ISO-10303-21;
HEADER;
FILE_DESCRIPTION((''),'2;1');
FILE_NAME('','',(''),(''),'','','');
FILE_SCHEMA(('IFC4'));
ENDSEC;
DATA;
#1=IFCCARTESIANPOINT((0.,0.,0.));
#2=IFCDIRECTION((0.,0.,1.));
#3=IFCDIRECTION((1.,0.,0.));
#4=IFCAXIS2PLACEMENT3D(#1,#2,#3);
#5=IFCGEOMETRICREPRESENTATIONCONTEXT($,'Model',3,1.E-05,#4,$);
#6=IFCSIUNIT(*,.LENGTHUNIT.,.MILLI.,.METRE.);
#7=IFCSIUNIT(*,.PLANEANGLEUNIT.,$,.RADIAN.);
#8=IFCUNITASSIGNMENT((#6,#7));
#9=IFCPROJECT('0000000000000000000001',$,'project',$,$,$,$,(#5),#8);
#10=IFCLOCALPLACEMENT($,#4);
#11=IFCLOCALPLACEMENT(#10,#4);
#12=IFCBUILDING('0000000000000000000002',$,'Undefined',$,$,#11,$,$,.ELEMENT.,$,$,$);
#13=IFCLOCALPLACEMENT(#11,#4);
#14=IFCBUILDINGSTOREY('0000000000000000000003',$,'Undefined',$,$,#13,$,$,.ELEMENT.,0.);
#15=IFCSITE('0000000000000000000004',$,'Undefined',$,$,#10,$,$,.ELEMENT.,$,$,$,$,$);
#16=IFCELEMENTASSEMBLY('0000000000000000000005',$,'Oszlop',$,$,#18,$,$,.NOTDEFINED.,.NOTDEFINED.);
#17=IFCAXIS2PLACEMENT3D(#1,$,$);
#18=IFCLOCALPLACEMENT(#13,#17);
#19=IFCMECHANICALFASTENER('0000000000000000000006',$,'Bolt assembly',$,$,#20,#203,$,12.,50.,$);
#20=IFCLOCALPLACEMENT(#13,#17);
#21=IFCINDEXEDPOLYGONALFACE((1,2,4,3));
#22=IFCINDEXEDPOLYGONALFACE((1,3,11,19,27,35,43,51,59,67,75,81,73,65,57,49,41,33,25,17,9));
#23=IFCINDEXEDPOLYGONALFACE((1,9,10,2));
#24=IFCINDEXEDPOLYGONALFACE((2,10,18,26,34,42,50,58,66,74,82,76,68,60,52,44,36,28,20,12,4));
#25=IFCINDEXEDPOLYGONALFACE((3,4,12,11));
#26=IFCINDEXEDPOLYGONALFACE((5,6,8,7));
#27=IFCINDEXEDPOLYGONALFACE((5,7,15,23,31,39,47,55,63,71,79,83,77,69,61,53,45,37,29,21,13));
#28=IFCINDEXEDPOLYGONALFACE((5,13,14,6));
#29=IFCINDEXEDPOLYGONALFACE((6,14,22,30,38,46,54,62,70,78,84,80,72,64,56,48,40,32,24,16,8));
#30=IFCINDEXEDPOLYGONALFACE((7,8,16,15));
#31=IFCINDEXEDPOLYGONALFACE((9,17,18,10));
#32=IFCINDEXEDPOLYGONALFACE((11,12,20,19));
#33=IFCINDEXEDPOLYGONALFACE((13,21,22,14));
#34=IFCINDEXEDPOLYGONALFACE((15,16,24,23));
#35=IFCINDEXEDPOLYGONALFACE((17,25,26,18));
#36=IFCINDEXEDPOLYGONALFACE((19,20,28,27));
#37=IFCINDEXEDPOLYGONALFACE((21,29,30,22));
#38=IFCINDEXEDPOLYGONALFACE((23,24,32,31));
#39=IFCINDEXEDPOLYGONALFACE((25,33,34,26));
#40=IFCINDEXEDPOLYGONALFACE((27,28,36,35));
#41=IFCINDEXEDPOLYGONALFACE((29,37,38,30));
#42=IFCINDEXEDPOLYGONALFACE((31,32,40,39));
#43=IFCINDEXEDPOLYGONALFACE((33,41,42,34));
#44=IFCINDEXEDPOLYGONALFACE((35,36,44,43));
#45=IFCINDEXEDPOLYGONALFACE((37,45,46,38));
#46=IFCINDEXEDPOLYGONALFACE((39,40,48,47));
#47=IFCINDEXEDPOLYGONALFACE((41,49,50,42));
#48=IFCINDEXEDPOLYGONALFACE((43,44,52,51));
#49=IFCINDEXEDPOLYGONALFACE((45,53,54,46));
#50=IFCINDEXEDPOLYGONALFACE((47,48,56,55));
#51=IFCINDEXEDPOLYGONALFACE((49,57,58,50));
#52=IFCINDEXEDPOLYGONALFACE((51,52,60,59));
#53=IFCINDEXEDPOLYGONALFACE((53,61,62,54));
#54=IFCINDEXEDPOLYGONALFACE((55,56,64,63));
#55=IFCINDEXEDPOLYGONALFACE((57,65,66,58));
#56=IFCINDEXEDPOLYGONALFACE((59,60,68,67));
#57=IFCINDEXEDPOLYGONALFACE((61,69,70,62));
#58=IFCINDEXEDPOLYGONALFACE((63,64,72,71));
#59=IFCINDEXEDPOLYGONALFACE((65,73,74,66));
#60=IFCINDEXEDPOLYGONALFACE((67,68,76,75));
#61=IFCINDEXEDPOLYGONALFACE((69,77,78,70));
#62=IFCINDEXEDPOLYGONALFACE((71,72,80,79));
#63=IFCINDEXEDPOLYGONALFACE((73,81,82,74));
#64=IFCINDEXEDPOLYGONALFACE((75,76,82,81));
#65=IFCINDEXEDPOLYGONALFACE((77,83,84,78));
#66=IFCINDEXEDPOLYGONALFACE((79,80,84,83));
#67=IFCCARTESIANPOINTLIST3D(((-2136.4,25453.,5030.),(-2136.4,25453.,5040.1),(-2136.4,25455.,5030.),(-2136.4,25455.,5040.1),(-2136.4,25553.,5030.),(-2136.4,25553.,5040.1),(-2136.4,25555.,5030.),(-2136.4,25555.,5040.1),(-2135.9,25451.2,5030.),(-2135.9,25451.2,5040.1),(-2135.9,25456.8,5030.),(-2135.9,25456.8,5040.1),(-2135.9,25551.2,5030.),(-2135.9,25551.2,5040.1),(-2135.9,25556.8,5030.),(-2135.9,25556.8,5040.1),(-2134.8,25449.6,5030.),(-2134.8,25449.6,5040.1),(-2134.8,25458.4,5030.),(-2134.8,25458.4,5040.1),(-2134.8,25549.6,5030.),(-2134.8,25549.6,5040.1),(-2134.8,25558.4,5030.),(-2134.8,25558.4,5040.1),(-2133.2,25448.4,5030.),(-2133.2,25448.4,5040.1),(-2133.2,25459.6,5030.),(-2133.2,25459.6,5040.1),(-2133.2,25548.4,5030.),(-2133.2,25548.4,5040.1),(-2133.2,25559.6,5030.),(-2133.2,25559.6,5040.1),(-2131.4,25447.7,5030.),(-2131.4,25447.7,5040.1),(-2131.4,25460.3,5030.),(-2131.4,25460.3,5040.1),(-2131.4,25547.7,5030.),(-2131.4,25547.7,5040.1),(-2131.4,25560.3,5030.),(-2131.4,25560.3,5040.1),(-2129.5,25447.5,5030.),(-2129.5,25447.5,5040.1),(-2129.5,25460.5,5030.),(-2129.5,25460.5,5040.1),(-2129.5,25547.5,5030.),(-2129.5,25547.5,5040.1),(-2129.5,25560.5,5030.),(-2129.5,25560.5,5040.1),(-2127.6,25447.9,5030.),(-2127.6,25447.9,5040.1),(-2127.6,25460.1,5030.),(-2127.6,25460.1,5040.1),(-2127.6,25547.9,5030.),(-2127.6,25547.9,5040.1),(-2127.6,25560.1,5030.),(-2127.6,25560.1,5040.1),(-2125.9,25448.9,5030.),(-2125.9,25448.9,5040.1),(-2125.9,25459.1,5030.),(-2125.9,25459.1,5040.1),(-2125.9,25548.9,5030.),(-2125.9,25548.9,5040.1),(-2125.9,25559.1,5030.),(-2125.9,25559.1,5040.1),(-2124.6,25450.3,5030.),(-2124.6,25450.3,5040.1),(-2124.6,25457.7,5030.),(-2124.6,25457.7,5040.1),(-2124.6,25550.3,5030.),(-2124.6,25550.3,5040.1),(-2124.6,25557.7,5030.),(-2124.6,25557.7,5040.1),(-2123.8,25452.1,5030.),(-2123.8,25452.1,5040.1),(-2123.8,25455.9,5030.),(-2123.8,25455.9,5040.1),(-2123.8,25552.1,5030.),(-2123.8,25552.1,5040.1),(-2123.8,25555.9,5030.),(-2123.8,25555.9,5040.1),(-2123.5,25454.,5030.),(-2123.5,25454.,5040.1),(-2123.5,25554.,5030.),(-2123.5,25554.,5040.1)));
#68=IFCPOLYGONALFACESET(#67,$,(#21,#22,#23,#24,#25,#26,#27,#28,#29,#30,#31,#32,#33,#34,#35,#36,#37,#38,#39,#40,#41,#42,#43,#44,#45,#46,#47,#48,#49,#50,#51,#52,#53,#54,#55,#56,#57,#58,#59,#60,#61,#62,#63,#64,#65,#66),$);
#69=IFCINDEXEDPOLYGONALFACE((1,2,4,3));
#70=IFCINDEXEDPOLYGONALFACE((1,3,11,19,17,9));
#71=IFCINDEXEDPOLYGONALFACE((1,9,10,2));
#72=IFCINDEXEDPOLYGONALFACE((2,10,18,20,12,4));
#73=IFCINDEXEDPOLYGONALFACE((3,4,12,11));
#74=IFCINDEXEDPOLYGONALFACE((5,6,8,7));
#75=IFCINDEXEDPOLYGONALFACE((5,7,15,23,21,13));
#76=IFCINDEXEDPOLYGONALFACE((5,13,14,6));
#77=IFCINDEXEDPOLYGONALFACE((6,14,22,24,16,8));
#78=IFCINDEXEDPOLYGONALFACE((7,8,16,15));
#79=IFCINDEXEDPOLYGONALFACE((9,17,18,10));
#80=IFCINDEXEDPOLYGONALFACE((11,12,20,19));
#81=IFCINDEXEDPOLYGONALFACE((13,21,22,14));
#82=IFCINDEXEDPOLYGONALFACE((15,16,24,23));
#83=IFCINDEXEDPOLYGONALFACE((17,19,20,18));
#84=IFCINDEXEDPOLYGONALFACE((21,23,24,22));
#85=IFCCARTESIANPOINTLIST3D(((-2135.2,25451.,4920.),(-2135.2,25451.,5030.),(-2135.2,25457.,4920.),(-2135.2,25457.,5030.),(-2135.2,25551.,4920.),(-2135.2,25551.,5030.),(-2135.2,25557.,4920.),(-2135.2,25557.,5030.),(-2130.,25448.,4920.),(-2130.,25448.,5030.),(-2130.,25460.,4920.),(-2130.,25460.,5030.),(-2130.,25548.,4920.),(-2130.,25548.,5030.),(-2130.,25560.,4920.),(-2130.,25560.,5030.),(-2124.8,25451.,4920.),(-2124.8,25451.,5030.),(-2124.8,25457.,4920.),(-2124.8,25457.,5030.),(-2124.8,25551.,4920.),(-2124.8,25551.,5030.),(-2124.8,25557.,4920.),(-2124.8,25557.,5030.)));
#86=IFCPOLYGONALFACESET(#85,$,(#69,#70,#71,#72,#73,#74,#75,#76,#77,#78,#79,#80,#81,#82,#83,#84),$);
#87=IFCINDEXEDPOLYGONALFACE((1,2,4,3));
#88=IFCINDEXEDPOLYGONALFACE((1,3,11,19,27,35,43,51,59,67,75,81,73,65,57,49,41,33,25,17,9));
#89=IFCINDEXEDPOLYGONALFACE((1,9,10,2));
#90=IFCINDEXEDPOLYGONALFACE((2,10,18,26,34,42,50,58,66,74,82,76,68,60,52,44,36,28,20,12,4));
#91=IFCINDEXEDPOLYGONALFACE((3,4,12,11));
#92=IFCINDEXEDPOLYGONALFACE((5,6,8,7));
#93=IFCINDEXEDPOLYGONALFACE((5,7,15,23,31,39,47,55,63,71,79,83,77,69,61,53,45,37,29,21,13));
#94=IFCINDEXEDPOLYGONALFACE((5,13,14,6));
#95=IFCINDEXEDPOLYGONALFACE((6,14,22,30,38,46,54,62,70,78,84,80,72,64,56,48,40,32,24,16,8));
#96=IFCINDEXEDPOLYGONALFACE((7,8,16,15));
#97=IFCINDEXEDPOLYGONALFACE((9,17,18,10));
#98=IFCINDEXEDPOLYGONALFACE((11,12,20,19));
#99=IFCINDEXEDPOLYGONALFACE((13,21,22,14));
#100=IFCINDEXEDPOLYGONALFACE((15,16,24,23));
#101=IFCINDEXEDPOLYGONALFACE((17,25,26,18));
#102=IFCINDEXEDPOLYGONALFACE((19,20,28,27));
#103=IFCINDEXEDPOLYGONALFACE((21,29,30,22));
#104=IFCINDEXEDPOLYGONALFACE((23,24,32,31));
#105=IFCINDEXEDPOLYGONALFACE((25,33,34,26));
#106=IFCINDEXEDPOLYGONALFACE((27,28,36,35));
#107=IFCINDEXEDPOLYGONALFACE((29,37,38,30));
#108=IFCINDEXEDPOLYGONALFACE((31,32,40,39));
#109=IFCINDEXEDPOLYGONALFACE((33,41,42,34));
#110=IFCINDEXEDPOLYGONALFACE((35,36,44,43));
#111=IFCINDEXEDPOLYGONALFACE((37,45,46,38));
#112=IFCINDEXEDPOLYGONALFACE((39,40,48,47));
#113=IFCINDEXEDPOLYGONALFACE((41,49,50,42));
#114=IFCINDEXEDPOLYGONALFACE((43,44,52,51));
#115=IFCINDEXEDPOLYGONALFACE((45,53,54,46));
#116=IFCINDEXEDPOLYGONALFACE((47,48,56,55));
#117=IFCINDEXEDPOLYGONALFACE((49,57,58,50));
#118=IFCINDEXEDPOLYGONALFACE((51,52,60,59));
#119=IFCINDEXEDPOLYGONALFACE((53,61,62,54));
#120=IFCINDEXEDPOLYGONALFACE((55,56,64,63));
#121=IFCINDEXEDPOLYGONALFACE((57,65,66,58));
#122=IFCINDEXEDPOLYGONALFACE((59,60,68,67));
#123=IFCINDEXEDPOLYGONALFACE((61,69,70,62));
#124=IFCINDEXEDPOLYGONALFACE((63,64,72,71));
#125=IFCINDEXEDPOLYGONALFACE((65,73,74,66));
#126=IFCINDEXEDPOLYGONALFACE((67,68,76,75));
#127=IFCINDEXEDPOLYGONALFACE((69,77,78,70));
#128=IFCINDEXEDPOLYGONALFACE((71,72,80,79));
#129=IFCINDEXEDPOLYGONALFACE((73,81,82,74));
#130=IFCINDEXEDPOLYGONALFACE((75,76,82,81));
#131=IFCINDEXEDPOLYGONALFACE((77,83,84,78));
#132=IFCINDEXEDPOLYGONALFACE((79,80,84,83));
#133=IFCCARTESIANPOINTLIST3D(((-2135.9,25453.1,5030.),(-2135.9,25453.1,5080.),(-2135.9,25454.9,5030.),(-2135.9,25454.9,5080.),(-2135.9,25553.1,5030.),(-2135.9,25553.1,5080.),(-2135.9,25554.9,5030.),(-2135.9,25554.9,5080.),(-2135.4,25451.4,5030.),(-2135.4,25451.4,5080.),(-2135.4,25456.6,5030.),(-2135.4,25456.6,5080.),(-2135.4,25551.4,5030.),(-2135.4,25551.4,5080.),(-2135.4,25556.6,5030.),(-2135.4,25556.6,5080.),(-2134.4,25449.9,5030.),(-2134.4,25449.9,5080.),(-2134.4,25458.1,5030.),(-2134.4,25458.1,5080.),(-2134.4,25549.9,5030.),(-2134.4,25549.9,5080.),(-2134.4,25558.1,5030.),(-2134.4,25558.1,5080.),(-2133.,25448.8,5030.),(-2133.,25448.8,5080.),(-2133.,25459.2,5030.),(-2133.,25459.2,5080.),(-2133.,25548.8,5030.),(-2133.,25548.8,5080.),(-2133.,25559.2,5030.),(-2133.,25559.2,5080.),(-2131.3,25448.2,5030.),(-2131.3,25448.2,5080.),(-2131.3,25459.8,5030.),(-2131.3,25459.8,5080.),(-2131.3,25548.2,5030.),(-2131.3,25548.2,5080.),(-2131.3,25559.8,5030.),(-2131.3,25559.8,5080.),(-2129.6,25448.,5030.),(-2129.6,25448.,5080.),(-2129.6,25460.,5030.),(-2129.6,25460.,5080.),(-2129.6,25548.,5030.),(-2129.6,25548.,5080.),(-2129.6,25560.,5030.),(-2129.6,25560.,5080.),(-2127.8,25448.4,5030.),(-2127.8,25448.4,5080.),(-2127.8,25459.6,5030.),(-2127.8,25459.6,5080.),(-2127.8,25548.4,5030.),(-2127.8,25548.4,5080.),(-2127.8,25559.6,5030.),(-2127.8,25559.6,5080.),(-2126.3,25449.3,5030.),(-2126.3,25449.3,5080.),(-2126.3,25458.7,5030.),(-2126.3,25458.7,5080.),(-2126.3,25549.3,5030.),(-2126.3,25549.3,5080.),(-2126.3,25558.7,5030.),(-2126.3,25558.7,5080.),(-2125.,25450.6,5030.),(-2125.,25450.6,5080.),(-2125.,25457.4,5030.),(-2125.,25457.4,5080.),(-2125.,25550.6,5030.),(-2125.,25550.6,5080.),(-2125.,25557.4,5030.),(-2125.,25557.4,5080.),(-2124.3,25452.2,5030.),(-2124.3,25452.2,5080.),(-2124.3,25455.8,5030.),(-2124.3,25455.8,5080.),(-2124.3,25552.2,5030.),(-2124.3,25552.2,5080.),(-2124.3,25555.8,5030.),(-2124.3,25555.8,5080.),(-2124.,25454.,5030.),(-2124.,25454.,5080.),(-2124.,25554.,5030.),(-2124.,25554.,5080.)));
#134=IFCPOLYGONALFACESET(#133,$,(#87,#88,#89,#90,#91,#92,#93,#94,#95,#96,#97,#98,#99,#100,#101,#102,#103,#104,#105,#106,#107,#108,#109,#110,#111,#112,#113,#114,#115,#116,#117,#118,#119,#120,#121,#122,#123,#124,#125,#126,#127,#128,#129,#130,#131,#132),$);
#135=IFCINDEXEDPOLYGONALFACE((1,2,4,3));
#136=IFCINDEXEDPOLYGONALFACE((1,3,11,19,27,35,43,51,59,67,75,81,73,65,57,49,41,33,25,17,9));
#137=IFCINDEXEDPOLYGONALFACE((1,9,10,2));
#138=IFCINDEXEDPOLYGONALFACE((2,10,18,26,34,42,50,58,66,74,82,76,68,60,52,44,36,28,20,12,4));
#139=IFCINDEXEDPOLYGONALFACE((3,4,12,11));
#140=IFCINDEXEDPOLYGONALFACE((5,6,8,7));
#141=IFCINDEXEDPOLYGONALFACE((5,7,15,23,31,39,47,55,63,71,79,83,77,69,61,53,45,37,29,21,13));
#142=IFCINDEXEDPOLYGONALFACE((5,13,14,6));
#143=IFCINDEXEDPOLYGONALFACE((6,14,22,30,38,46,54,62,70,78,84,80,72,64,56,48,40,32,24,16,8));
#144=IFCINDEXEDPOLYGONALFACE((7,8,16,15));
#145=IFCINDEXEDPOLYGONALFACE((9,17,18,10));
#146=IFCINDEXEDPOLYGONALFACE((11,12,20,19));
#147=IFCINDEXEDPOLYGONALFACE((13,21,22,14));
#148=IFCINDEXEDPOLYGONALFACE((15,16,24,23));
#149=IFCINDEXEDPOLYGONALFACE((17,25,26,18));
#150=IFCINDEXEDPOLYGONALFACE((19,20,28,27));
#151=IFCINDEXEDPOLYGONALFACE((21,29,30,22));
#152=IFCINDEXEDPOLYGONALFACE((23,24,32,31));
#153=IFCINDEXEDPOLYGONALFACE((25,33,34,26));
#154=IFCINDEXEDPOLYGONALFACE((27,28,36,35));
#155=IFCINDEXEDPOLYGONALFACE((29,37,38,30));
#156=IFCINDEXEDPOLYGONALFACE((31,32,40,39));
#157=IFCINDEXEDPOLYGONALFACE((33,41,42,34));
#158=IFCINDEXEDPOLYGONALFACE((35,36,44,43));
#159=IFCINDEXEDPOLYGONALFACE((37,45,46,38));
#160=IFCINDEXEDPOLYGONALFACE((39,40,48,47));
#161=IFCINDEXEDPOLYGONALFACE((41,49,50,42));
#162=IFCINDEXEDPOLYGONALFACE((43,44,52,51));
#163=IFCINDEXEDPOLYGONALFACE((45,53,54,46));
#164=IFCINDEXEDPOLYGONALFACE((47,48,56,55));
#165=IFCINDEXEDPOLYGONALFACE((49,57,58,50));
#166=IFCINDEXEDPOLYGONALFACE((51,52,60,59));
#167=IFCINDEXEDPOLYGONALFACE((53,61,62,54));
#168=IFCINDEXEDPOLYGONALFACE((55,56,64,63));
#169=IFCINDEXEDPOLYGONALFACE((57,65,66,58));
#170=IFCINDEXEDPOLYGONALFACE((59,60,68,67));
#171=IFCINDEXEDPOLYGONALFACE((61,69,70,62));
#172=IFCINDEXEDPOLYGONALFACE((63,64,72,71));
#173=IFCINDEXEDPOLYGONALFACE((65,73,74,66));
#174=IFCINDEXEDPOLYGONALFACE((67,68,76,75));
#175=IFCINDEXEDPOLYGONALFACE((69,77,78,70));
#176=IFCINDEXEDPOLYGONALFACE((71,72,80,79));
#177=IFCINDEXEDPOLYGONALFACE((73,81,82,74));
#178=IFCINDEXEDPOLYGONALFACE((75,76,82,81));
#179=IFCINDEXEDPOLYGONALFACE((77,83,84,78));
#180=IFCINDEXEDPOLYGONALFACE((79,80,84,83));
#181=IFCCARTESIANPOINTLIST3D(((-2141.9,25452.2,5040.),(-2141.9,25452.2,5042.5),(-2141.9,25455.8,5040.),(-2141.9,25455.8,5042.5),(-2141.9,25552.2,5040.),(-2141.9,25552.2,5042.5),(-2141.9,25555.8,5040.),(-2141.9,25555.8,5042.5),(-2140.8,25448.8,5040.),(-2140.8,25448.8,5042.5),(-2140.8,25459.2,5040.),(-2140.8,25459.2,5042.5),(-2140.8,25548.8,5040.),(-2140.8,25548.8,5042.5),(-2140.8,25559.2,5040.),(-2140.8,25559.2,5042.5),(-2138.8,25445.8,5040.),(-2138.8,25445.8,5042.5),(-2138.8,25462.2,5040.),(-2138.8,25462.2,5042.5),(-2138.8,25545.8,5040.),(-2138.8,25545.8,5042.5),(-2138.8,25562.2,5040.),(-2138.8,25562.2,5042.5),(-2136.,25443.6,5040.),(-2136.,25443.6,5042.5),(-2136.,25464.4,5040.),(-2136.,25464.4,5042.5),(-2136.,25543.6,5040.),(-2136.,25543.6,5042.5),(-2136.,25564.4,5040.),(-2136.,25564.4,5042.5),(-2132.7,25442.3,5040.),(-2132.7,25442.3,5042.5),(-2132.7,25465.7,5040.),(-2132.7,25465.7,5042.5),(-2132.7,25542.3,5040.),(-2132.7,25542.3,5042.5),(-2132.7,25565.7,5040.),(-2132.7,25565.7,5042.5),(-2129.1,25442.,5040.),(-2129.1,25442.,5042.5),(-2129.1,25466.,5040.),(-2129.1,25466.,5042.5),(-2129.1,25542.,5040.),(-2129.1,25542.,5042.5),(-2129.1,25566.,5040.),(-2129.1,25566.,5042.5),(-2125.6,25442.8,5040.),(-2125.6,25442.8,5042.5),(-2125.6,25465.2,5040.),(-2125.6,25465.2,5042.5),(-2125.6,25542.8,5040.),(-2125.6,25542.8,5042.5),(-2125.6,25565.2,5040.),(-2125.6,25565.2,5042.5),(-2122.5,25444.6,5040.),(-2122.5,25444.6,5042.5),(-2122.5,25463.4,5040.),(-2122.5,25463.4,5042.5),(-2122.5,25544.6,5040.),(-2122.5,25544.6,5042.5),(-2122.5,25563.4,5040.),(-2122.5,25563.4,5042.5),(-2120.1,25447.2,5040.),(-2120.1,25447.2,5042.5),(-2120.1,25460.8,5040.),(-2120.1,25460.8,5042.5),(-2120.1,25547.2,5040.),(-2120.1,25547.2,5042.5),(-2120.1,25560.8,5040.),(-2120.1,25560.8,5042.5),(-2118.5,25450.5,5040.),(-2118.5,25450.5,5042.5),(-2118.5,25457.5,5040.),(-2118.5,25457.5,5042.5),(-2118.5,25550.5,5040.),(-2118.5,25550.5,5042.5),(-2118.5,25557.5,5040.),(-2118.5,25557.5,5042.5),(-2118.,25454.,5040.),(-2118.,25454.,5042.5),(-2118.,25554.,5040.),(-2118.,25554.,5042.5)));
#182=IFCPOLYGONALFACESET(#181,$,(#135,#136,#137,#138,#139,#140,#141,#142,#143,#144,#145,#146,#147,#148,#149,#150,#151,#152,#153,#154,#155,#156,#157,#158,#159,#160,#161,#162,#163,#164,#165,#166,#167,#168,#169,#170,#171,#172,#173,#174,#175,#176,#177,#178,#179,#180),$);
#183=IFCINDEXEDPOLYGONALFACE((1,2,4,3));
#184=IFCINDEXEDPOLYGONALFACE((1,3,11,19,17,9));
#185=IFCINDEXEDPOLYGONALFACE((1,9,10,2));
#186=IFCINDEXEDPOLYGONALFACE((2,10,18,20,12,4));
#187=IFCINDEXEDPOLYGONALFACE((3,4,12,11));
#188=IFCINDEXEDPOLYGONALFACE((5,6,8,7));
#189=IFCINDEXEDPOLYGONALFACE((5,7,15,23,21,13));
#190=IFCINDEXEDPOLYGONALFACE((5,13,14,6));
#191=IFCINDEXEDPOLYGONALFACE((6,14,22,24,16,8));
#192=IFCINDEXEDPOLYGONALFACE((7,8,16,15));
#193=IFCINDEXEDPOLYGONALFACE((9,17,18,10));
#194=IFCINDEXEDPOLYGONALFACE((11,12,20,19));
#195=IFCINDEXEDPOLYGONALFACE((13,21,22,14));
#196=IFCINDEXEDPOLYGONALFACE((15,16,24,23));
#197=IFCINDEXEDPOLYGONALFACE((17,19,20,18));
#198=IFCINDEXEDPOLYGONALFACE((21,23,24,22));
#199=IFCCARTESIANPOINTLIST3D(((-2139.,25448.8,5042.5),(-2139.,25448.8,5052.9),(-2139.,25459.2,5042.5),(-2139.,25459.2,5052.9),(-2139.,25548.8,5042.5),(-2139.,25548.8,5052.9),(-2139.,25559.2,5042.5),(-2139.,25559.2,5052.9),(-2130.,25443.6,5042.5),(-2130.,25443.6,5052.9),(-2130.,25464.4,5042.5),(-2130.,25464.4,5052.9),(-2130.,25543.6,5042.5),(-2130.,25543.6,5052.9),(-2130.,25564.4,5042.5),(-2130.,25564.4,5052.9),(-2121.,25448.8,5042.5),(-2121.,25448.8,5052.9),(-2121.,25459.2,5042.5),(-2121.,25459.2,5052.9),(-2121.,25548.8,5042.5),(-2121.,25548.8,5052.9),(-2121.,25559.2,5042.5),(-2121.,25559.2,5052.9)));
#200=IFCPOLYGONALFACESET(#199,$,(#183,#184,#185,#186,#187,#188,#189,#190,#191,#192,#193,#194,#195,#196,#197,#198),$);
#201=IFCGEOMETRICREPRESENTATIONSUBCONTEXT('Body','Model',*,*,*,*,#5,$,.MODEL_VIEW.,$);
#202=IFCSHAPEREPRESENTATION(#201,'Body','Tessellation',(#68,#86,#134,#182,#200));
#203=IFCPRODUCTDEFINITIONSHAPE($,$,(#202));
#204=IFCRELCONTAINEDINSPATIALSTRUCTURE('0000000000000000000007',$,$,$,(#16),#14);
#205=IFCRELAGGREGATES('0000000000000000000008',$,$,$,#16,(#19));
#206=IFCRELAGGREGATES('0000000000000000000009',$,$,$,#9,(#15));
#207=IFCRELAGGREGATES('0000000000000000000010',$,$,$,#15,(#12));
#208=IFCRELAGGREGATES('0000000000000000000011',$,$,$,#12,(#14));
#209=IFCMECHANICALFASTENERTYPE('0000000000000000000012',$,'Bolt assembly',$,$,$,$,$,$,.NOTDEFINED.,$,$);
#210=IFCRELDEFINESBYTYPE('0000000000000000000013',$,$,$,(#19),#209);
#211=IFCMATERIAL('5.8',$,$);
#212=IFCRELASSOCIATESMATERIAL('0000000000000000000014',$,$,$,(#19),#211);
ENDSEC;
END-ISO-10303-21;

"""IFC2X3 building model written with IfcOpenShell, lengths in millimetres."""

from ifc_helpers import new_model, si_unit, frame, origin_with_axes, origin_2d_with_axis, place, context, subcontext, project, spatial, polyline, circle, outline, extrude, source, transform, mapped, material, type_object, element, aggregate, save


model = new_model("IFC2X3")

# Units and contexts
model_context = context("Model", 3, precision=1e-05, world=origin_with_axes())
body_context = subcontext(model_context, "Body", "Model", "MODEL_VIEW")
ifc_project = project(units=[si_unit("LENGTHUNIT", "METRE", prefix="MILLI"), si_unit("PLANEANGLEUNIT", "RADIAN")], contexts=[model_context])

# Site, building, storey
site_placement = place(None, origin_with_axes())
site = spatial("IfcSite", under=ifc_project, at=site_placement, Name="Undefined", CompositionType="ELEMENT")
building_placement = place(site_placement, origin_with_axes())
building = spatial("IfcBuilding", under=site, at=building_placement, Name="Undefined", CompositionType="ELEMENT")
storey_placement = place(building_placement, origin_with_axes())
storey = spatial("IfcBuildingStorey", under=building, at=storey_placement, Name="Undefined", CompositionType="ELEMENT", Elevation=0.0)

# Element assembly
assembly_1_placement = place(storey_placement, origin_with_axes())
assembly_1 = element("IfcElementAssembly", 1, at=assembly_1_placement, inside=storey, Name="Oszlop", AssemblyPlace="NOTDEFINED", PredefinedType="NOTDEFINED")

# Mechanical fastener
mechanical_fastener_type = type_object("IfcMechanicalFastenerType", Name="Bolt assembly")
ifc_material_1 = material(Name="5.8")
shared_shape_1 = source(origin_with_axes(), body_context, "Body", "SweptSolid", [
    extrude(circle(Radius=6.5, at=origin_2d_with_axis()), frame((0.0, -10.0, 0.0), z_axis=(0.0, 1.0, 0.0), x_axis=(1.0, 0.0, 0.0)), (0.0, 0.0, 1.0), 10.1),
    extrude(outline(polyline([(5.2, -3.0), (5.2, 3.0), (0.0, 6.0), (-5.2, 3.0), (-5.2, -3.0), (0.0, -6.0), (5.2, -3.0)])), frame((0.0, -120.0, 0.0), z_axis=(0.0, 1.0, 0.0), x_axis=(1.0, 0.0, 0.0)), (0.0, 0.0, 1.0), 110.0),
    extrude(circle(Radius=6.0, at=origin_2d_with_axis()), frame((0.0, -10.0, 0.0), z_axis=(0.0, 1.0, 0.0), x_axis=(1.0, 0.0, 0.0)), (0.0, 0.0, 1.0), 50.0),
    extrude(circle(Radius=12.0, at=origin_2d_with_axis()), frame((0.0, 0.0, 0.0), z_axis=(0.0, 1.0, 0.0), x_axis=(1.0, 0.0, 0.0)), (0.0, 0.0, 1.0), 2.5),
    extrude(outline(polyline([(9.0, -5.2), (9.0, 5.2), (0.0, 10.4), (-9.0, 5.2), (-9.0, -5.2), (0.0, -10.4), (9.0, -5.2)])), frame((0.0, 2.5, 0.0), z_axis=(0.0, 1.0, 0.0), x_axis=(1.0, 0.0, 0.0)), (0.0, 0.0, 1.0), 10.4),
])
mechanical_fastener_1_placement = place(assembly_1_placement, frame((-2178.0, 25504.0, 5040.0), z_axis=(0.0, -1.0, 0.0), x_axis=(1.0, 0.0, 0.0)))
mechanical_fastener_1 = element("IfcMechanicalFastener", 2, at=mechanical_fastener_1_placement, type_object=mechanical_fastener_type, material=ifc_material_1, Name="Bolt assembly", NominalDiameter=12.0, NominalLength=50.0, context=body_context, shape_type="MappedRepresentation", body=[
    mapped(shared_shape_1, transform((48.0, 0.0, -50.0))),
    mapped(shared_shape_1, transform((48.0, 0.0, 50.0))),
])
aggregate(assembly_1, [mechanical_fastener_1])

save(model, "model.ifc")
